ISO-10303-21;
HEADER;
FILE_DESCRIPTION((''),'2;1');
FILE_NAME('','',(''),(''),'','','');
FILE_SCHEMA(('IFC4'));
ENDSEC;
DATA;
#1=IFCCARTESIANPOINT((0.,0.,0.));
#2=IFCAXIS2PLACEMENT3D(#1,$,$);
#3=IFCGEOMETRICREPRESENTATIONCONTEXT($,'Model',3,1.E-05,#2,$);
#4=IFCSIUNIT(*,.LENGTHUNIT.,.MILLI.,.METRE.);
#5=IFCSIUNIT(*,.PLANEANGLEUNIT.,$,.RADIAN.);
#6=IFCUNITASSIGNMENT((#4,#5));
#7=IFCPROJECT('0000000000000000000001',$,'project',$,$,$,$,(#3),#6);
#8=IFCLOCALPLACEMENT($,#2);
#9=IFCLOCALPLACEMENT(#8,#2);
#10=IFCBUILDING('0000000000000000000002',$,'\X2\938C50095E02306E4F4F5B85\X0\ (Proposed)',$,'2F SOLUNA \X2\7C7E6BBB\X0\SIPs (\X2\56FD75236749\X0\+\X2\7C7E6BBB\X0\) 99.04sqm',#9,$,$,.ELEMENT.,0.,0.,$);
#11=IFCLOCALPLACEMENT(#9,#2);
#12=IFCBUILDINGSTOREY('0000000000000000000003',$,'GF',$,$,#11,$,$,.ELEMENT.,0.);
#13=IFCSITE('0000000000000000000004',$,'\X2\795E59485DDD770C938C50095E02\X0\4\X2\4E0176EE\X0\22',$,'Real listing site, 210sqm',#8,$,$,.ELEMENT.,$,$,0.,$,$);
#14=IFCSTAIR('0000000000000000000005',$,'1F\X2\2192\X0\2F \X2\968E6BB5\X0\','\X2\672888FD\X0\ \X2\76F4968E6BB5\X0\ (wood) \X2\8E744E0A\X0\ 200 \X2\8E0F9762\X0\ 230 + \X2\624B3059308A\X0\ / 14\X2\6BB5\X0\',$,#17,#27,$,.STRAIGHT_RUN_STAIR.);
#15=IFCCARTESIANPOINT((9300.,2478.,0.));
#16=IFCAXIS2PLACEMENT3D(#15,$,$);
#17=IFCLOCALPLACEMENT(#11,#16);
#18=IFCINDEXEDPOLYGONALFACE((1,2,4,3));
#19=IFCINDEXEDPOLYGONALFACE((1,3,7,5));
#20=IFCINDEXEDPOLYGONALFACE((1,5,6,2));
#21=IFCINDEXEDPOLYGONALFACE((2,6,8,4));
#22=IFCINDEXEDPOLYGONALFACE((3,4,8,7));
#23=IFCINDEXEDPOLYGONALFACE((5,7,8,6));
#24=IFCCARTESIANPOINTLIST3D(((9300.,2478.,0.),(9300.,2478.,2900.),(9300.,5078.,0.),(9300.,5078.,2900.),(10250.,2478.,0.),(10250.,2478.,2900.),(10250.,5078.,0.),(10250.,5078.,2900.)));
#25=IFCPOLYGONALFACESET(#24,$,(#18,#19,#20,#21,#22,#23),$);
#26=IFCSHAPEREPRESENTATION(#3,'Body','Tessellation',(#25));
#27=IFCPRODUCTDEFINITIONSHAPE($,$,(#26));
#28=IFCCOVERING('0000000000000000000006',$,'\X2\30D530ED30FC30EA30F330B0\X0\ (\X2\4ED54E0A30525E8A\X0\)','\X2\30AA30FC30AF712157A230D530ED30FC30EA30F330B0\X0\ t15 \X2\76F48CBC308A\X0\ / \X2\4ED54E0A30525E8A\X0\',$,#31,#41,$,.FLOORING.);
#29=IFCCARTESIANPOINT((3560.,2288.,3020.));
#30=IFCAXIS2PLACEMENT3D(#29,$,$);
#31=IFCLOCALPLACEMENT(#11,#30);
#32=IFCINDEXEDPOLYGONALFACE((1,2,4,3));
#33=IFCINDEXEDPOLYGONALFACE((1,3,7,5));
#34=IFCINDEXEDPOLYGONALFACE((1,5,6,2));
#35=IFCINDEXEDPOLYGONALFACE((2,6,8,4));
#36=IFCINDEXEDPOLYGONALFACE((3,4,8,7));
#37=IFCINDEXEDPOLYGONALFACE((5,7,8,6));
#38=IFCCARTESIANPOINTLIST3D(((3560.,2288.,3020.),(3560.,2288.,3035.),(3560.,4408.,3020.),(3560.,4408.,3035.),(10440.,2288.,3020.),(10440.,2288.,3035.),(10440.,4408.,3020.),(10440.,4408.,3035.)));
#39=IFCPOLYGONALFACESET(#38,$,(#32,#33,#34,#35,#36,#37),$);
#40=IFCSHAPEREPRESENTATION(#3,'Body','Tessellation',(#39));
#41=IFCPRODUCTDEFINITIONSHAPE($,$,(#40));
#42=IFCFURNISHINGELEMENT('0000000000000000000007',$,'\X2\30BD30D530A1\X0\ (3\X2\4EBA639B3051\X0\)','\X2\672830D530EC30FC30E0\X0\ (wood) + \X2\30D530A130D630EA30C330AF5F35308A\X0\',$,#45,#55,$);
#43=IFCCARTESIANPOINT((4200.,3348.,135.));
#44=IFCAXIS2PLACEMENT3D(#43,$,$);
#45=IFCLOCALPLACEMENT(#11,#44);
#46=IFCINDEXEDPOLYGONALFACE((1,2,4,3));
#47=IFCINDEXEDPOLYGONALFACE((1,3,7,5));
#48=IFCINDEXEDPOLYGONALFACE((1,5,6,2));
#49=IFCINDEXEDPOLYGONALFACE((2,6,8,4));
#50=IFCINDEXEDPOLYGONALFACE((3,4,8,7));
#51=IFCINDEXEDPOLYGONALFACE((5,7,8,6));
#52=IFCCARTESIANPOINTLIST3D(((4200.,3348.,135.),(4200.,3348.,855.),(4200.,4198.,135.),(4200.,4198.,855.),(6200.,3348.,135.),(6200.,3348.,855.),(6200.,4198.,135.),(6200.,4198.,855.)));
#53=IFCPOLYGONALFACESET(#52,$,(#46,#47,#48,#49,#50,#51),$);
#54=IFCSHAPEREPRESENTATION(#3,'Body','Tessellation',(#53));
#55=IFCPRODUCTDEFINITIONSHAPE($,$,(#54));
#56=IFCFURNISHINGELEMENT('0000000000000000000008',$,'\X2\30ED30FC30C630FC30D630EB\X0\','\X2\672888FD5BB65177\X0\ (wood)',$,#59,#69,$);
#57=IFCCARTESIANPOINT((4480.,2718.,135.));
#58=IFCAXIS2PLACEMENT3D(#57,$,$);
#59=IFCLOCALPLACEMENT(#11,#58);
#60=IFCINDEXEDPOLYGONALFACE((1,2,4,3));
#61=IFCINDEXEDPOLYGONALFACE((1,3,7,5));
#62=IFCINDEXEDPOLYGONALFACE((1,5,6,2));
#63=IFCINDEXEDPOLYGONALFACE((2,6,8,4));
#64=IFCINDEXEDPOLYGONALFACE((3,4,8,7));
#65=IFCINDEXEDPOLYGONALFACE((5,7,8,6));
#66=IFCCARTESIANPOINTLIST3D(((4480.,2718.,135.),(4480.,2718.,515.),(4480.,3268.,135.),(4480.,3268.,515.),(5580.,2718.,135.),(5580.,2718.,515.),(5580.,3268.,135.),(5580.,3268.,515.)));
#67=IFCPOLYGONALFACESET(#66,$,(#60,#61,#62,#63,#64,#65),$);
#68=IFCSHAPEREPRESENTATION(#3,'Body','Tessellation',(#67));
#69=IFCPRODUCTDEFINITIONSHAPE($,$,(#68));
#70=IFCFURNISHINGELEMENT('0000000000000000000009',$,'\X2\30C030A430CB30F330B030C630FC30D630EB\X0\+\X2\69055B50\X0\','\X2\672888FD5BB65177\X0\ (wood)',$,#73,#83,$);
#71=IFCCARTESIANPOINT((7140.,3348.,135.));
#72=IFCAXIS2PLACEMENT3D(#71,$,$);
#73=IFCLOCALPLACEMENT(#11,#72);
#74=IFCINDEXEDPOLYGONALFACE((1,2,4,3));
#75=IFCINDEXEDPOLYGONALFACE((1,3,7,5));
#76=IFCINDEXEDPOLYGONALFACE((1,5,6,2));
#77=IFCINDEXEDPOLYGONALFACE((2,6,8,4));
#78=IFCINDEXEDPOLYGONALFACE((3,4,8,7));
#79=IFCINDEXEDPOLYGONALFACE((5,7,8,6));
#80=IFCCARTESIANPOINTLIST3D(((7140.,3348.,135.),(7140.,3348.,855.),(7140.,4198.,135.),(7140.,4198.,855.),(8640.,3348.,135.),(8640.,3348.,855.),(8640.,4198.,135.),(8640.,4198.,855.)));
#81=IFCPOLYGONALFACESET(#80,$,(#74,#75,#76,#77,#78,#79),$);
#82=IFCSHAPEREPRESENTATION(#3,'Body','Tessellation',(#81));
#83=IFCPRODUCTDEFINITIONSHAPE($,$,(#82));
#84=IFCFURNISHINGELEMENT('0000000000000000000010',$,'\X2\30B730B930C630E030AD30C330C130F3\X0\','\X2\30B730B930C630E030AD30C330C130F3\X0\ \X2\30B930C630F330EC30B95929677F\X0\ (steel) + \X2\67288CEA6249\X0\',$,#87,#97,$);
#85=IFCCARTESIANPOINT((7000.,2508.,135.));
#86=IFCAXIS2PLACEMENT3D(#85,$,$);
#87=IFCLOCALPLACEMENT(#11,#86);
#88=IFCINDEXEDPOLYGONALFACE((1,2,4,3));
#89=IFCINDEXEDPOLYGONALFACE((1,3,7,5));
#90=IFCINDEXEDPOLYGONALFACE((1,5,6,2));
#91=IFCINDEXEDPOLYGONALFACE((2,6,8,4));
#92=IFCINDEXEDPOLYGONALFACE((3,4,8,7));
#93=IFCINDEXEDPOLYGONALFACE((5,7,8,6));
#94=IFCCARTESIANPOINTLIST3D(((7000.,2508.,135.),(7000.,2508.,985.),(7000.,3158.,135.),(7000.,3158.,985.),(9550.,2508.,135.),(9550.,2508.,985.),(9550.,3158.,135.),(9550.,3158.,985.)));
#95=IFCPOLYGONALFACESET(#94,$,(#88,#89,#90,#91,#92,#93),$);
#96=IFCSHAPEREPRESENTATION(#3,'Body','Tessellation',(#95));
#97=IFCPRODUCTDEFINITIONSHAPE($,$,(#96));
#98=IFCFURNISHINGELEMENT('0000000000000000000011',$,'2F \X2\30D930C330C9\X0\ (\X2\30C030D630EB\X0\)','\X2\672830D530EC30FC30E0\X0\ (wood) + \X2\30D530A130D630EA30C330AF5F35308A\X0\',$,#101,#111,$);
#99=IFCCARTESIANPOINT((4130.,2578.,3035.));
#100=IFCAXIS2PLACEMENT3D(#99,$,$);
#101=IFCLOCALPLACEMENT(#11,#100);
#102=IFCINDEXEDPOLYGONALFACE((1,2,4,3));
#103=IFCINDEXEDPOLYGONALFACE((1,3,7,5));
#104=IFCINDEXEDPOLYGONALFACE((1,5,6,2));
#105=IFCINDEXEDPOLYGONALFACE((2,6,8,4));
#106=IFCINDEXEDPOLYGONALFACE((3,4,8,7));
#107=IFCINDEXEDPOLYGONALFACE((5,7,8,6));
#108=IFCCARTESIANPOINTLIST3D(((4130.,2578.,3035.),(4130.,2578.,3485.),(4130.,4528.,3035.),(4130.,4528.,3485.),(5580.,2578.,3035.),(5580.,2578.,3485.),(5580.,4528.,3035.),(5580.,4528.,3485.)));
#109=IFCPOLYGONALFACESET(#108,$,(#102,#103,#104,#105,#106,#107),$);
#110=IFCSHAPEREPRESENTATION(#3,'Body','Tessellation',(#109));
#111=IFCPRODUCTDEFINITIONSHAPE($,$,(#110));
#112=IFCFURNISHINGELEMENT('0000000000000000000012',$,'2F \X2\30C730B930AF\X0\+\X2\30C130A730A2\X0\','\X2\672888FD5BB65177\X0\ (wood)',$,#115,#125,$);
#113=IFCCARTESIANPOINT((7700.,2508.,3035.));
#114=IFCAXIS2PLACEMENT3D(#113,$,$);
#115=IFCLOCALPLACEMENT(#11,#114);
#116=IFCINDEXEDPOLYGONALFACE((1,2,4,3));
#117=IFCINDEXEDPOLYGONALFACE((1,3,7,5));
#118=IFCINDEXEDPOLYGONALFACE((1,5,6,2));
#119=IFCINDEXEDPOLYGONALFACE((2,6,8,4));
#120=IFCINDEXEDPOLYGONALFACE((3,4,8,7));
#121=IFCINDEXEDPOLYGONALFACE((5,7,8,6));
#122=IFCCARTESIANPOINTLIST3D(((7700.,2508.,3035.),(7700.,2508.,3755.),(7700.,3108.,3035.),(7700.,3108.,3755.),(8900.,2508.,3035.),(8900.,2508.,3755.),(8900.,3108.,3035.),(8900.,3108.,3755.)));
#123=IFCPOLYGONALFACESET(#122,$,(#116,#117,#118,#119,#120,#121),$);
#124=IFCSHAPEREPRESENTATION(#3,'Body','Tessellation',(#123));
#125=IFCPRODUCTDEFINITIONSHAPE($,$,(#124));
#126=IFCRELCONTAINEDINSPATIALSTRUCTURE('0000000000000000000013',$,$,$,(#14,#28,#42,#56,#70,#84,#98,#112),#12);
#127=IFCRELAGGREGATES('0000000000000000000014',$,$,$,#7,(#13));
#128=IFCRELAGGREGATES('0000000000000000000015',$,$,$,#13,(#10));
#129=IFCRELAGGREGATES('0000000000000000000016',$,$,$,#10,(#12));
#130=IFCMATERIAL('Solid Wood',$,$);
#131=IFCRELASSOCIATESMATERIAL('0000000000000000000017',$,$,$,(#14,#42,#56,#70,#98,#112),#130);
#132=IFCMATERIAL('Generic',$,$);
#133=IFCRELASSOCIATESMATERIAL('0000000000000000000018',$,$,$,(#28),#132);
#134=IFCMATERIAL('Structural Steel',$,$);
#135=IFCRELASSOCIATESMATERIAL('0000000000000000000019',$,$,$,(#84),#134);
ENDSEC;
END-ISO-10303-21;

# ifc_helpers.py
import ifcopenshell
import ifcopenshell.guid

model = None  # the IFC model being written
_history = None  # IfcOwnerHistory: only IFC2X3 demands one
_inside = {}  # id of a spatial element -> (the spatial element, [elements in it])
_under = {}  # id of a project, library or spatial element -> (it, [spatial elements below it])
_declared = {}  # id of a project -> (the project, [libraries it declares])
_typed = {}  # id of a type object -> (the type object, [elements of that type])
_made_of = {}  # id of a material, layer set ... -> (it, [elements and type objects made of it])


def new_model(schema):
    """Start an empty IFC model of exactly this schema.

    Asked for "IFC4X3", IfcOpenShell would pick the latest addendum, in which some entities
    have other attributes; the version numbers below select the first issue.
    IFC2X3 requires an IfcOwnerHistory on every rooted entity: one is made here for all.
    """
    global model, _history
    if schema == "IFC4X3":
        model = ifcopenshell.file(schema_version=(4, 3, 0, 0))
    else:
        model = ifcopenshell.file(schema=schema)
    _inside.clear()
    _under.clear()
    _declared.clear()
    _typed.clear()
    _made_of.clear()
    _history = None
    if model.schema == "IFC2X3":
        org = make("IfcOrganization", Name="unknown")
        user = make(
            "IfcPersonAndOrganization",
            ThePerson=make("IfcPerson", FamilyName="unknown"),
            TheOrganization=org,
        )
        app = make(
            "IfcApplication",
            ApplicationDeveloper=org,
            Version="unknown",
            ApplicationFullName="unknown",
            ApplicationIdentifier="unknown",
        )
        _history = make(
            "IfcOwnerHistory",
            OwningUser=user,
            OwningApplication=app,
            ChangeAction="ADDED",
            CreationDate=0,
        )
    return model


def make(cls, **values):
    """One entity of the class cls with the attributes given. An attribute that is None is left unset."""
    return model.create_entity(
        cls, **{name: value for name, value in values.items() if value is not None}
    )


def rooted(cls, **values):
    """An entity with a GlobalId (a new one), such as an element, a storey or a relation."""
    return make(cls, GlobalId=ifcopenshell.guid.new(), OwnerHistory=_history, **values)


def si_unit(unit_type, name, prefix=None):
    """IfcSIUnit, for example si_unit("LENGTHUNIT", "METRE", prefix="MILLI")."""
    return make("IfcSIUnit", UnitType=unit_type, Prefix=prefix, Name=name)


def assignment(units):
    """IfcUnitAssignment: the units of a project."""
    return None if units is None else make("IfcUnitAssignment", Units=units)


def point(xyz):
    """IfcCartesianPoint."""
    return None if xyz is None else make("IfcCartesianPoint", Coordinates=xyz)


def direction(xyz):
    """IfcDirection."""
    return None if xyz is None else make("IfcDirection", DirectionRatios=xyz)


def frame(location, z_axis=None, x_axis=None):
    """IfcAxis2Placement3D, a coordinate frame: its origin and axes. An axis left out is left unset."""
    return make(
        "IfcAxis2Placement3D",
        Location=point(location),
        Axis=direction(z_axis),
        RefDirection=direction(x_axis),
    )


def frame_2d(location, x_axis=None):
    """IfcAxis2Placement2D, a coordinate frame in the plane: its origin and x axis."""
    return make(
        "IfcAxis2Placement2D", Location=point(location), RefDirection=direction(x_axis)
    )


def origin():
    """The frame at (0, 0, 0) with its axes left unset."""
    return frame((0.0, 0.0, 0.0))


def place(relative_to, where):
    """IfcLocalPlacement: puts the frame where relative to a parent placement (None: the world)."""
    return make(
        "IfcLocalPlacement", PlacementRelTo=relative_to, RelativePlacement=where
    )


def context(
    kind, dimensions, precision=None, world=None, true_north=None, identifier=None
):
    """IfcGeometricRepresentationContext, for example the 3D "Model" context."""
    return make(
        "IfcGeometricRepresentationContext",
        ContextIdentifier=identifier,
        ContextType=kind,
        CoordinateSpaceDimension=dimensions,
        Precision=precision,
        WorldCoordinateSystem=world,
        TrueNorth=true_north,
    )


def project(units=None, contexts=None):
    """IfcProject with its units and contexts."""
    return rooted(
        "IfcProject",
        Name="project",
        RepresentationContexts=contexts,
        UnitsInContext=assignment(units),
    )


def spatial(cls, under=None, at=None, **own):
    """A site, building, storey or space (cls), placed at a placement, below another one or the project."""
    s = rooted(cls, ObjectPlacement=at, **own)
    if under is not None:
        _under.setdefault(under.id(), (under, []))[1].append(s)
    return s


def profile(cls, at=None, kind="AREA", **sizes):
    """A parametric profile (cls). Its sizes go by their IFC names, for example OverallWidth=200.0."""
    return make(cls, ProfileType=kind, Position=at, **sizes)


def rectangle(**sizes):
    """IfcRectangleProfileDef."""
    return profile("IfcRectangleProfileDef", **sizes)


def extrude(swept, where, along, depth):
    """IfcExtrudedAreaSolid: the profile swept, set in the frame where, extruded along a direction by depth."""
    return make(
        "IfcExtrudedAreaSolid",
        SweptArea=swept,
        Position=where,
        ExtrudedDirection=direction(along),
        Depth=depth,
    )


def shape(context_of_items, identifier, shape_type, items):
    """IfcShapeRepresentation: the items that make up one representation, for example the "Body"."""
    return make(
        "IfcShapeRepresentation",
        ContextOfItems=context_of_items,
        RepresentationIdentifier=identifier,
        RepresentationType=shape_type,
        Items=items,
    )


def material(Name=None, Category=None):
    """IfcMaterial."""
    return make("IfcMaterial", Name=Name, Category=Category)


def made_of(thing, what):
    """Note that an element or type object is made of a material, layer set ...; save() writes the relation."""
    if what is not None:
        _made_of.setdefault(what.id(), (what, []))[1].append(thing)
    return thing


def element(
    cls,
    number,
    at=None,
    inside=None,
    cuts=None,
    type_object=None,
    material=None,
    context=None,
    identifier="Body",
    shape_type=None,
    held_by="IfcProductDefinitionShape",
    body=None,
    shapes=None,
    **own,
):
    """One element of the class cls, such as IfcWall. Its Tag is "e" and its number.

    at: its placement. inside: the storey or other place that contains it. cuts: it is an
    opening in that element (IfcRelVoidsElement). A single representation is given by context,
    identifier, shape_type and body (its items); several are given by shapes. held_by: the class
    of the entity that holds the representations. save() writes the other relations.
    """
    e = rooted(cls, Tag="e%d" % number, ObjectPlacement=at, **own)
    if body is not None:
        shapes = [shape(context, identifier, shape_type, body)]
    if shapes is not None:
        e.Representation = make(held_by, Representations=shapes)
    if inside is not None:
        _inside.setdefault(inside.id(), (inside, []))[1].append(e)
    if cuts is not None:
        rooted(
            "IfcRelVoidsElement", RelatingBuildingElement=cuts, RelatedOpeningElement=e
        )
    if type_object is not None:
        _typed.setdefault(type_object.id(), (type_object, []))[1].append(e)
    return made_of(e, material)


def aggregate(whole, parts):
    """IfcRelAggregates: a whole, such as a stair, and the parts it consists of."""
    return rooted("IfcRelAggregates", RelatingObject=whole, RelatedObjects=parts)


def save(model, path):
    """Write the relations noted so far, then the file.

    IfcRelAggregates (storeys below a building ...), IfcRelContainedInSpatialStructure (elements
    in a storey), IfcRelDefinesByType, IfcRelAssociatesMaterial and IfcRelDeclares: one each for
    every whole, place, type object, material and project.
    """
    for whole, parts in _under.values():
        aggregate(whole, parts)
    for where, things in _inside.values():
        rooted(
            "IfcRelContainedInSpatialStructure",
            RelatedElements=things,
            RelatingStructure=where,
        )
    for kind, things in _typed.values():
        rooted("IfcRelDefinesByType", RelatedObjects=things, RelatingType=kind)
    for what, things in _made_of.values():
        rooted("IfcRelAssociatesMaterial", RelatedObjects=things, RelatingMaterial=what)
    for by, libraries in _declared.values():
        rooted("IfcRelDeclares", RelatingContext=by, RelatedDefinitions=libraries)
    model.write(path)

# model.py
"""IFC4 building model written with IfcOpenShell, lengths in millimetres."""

from ifc_helpers import new_model, si_unit, frame, frame_2d, origin, place, context, project, spatial, rectangle, extrude, material, element, save


model = new_model("IFC4")

# Units and contexts
model_context = context("Model", 3, precision=1e-05, world=origin())
ifc_project = project(units=[si_unit("LENGTHUNIT", "METRE", prefix="MILLI"), si_unit("PLANEANGLEUNIT", "RADIAN")], contexts=[model_context])

# Site, building, storey
site_placement = place(None, origin())
site = spatial("IfcSite", under=ifc_project, at=site_placement, Name="神奈川県鎌倉市4丁目22", ObjectType="Real listing site, 210sqm", CompositionType="ELEMENT", RefElevation=0.0)
building_placement = place(site_placement, origin())
building = spatial("IfcBuilding", under=site, at=building_placement, Name="鎌倉市の住宅 (Proposed)", ObjectType="2F SOLUNA 籾殻SIPs (国産杉+籾殻) 99.04sqm", CompositionType="ELEMENT", ElevationOfRefHeight=0.0, ElevationOfTerrain=0.0)
storey_placement = place(building_placement, origin())
storey = spatial("IfcBuildingStorey", under=building, at=storey_placement, Name="GF", CompositionType="ELEMENT", Elevation=0.0)

# Shared definitions
ifc_material_1 = material(Name="Solid Wood")

# Shared definitions
ifc_material_2 = material(Name="Generic")

# Stair
stair_placement = place(storey_placement, frame((9300.0, 2478.0, 0.0)))
element("IfcStair", 1, at=stair_placement, inside=storey, material=ifc_material_1, Name="1F→2F 階段", Description="木製 直階段 (wood) 蹴上 200 踏面 230 + 手すり / 14段", PredefinedType="STRAIGHT_RUN_STAIR", context=model_context, shape_type="SweptSolid", body=[
    extrude(rectangle(XDim=950.0, YDim=2600.0, at=frame_2d((475.0, 1300.0))), frame((9300.0, 2478.0, 0.0)), (0.0, 0.0, 1.0), 2900.0),
])

# Covering
covering_placement = place(storey_placement, frame((3560.0, 2288.0, 3020.0)))
element("IfcCovering", 2, at=covering_placement, inside=storey, material=ifc_material_2, Name="フローリング (仕上げ床)", Description="オーク無垢フローリング t15 直貼り / 仕上げ床", PredefinedType="FLOORING", context=model_context, shape_type="SweptSolid", body=[
    extrude(rectangle(XDim=6880.0, YDim=2120.0, at=frame_2d((3440.0, 1060.0))), frame((3560.0, 2288.0, 3020.0)), (0.0, 0.0, 1.0), 15.0),
])

# Furnishing elements
furnishing_1_placement = place(storey_placement, frame((4200.0, 3348.0, 135.0)))
element("IfcFurnishingElement", 3, at=furnishing_1_placement, inside=storey, material=ifc_material_1, Name="ソファ (3人掛け)", Description="木フレーム (wood) + ファブリック張り", context=model_context, shape_type="SweptSolid", body=[
    extrude(rectangle(XDim=2000.0, YDim=850.0, at=frame_2d((1000.0, 425.0))), frame((4200.0, 3348.0, 135.0)), (0.0, 0.0, 1.0), 720.0),
])
furnishing_2_placement = place(storey_placement, frame((4480.0, 2718.0, 135.0)))
element("IfcFurnishingElement", 4, at=furnishing_2_placement, inside=storey, material=ifc_material_1, Name="ローテーブル", Description="木製家具 (wood)", context=model_context, shape_type="SweptSolid", body=[
    extrude(rectangle(XDim=1100.0, YDim=550.0, at=frame_2d((550.0, 275.0))), frame((4480.0, 2718.0, 135.0)), (0.0, 0.0, 1.0), 380.0),
])
furnishing_3_placement = place(storey_placement, frame((7140.0, 3348.0, 135.0)))
element("IfcFurnishingElement", 5, at=furnishing_3_placement, inside=storey, material=ifc_material_1, Name="ダイニングテーブル+椅子", Description="木製家具 (wood)", context=model_context, shape_type="SweptSolid", body=[
    extrude(rectangle(XDim=1500.0, YDim=850.0, at=frame_2d((750.0, 425.0))), frame((7140.0, 3348.0, 135.0)), (0.0, 0.0, 1.0), 720.0),
])
ifc_material_3 = material(Name="Structural Steel")
furnishing_4_placement = place(storey_placement, frame((7000.0, 2508.0, 135.0)))
element("IfcFurnishingElement", 6, at=furnishing_4_placement, inside=storey, material=ifc_material_3, Name="システムキッチン", Description="システムキッチン ステンレス天板 (steel) + 木質扉", context=model_context, shape_type="SweptSolid", body=[
    extrude(rectangle(XDim=2550.0, YDim=650.0, at=frame_2d((1275.0, 325.0))), frame((7000.0, 2508.0, 135.0)), (0.0, 0.0, 1.0), 850.0),
])
furnishing_5_placement = place(storey_placement, frame((4130.0, 2578.0, 3035.0)))
element("IfcFurnishingElement", 7, at=furnishing_5_placement, inside=storey, material=ifc_material_1, Name="2F ベッド (ダブル)", Description="木フレーム (wood) + ファブリック張り", context=model_context, shape_type="SweptSolid", body=[
    extrude(rectangle(XDim=1450.0, YDim=1950.0, at=frame_2d((725.0, 975.0))), frame((4130.0, 2578.0, 3035.0)), (0.0, 0.0, 1.0), 450.0),
])
furnishing_6_placement = place(storey_placement, frame((7700.0, 2508.0, 3035.0)))
element("IfcFurnishingElement", 8, at=furnishing_6_placement, inside=storey, material=ifc_material_1, Name="2F デスク+チェア", Description="木製家具 (wood)", context=model_context, shape_type="SweptSolid", body=[
    extrude(rectangle(XDim=1200.0, YDim=600.0, at=frame_2d((600.0, 300.0))), frame((7700.0, 2508.0, 3035.0)), (0.0, 0.0, 1.0), 720.0),
])

save(model, "model.ifc")
